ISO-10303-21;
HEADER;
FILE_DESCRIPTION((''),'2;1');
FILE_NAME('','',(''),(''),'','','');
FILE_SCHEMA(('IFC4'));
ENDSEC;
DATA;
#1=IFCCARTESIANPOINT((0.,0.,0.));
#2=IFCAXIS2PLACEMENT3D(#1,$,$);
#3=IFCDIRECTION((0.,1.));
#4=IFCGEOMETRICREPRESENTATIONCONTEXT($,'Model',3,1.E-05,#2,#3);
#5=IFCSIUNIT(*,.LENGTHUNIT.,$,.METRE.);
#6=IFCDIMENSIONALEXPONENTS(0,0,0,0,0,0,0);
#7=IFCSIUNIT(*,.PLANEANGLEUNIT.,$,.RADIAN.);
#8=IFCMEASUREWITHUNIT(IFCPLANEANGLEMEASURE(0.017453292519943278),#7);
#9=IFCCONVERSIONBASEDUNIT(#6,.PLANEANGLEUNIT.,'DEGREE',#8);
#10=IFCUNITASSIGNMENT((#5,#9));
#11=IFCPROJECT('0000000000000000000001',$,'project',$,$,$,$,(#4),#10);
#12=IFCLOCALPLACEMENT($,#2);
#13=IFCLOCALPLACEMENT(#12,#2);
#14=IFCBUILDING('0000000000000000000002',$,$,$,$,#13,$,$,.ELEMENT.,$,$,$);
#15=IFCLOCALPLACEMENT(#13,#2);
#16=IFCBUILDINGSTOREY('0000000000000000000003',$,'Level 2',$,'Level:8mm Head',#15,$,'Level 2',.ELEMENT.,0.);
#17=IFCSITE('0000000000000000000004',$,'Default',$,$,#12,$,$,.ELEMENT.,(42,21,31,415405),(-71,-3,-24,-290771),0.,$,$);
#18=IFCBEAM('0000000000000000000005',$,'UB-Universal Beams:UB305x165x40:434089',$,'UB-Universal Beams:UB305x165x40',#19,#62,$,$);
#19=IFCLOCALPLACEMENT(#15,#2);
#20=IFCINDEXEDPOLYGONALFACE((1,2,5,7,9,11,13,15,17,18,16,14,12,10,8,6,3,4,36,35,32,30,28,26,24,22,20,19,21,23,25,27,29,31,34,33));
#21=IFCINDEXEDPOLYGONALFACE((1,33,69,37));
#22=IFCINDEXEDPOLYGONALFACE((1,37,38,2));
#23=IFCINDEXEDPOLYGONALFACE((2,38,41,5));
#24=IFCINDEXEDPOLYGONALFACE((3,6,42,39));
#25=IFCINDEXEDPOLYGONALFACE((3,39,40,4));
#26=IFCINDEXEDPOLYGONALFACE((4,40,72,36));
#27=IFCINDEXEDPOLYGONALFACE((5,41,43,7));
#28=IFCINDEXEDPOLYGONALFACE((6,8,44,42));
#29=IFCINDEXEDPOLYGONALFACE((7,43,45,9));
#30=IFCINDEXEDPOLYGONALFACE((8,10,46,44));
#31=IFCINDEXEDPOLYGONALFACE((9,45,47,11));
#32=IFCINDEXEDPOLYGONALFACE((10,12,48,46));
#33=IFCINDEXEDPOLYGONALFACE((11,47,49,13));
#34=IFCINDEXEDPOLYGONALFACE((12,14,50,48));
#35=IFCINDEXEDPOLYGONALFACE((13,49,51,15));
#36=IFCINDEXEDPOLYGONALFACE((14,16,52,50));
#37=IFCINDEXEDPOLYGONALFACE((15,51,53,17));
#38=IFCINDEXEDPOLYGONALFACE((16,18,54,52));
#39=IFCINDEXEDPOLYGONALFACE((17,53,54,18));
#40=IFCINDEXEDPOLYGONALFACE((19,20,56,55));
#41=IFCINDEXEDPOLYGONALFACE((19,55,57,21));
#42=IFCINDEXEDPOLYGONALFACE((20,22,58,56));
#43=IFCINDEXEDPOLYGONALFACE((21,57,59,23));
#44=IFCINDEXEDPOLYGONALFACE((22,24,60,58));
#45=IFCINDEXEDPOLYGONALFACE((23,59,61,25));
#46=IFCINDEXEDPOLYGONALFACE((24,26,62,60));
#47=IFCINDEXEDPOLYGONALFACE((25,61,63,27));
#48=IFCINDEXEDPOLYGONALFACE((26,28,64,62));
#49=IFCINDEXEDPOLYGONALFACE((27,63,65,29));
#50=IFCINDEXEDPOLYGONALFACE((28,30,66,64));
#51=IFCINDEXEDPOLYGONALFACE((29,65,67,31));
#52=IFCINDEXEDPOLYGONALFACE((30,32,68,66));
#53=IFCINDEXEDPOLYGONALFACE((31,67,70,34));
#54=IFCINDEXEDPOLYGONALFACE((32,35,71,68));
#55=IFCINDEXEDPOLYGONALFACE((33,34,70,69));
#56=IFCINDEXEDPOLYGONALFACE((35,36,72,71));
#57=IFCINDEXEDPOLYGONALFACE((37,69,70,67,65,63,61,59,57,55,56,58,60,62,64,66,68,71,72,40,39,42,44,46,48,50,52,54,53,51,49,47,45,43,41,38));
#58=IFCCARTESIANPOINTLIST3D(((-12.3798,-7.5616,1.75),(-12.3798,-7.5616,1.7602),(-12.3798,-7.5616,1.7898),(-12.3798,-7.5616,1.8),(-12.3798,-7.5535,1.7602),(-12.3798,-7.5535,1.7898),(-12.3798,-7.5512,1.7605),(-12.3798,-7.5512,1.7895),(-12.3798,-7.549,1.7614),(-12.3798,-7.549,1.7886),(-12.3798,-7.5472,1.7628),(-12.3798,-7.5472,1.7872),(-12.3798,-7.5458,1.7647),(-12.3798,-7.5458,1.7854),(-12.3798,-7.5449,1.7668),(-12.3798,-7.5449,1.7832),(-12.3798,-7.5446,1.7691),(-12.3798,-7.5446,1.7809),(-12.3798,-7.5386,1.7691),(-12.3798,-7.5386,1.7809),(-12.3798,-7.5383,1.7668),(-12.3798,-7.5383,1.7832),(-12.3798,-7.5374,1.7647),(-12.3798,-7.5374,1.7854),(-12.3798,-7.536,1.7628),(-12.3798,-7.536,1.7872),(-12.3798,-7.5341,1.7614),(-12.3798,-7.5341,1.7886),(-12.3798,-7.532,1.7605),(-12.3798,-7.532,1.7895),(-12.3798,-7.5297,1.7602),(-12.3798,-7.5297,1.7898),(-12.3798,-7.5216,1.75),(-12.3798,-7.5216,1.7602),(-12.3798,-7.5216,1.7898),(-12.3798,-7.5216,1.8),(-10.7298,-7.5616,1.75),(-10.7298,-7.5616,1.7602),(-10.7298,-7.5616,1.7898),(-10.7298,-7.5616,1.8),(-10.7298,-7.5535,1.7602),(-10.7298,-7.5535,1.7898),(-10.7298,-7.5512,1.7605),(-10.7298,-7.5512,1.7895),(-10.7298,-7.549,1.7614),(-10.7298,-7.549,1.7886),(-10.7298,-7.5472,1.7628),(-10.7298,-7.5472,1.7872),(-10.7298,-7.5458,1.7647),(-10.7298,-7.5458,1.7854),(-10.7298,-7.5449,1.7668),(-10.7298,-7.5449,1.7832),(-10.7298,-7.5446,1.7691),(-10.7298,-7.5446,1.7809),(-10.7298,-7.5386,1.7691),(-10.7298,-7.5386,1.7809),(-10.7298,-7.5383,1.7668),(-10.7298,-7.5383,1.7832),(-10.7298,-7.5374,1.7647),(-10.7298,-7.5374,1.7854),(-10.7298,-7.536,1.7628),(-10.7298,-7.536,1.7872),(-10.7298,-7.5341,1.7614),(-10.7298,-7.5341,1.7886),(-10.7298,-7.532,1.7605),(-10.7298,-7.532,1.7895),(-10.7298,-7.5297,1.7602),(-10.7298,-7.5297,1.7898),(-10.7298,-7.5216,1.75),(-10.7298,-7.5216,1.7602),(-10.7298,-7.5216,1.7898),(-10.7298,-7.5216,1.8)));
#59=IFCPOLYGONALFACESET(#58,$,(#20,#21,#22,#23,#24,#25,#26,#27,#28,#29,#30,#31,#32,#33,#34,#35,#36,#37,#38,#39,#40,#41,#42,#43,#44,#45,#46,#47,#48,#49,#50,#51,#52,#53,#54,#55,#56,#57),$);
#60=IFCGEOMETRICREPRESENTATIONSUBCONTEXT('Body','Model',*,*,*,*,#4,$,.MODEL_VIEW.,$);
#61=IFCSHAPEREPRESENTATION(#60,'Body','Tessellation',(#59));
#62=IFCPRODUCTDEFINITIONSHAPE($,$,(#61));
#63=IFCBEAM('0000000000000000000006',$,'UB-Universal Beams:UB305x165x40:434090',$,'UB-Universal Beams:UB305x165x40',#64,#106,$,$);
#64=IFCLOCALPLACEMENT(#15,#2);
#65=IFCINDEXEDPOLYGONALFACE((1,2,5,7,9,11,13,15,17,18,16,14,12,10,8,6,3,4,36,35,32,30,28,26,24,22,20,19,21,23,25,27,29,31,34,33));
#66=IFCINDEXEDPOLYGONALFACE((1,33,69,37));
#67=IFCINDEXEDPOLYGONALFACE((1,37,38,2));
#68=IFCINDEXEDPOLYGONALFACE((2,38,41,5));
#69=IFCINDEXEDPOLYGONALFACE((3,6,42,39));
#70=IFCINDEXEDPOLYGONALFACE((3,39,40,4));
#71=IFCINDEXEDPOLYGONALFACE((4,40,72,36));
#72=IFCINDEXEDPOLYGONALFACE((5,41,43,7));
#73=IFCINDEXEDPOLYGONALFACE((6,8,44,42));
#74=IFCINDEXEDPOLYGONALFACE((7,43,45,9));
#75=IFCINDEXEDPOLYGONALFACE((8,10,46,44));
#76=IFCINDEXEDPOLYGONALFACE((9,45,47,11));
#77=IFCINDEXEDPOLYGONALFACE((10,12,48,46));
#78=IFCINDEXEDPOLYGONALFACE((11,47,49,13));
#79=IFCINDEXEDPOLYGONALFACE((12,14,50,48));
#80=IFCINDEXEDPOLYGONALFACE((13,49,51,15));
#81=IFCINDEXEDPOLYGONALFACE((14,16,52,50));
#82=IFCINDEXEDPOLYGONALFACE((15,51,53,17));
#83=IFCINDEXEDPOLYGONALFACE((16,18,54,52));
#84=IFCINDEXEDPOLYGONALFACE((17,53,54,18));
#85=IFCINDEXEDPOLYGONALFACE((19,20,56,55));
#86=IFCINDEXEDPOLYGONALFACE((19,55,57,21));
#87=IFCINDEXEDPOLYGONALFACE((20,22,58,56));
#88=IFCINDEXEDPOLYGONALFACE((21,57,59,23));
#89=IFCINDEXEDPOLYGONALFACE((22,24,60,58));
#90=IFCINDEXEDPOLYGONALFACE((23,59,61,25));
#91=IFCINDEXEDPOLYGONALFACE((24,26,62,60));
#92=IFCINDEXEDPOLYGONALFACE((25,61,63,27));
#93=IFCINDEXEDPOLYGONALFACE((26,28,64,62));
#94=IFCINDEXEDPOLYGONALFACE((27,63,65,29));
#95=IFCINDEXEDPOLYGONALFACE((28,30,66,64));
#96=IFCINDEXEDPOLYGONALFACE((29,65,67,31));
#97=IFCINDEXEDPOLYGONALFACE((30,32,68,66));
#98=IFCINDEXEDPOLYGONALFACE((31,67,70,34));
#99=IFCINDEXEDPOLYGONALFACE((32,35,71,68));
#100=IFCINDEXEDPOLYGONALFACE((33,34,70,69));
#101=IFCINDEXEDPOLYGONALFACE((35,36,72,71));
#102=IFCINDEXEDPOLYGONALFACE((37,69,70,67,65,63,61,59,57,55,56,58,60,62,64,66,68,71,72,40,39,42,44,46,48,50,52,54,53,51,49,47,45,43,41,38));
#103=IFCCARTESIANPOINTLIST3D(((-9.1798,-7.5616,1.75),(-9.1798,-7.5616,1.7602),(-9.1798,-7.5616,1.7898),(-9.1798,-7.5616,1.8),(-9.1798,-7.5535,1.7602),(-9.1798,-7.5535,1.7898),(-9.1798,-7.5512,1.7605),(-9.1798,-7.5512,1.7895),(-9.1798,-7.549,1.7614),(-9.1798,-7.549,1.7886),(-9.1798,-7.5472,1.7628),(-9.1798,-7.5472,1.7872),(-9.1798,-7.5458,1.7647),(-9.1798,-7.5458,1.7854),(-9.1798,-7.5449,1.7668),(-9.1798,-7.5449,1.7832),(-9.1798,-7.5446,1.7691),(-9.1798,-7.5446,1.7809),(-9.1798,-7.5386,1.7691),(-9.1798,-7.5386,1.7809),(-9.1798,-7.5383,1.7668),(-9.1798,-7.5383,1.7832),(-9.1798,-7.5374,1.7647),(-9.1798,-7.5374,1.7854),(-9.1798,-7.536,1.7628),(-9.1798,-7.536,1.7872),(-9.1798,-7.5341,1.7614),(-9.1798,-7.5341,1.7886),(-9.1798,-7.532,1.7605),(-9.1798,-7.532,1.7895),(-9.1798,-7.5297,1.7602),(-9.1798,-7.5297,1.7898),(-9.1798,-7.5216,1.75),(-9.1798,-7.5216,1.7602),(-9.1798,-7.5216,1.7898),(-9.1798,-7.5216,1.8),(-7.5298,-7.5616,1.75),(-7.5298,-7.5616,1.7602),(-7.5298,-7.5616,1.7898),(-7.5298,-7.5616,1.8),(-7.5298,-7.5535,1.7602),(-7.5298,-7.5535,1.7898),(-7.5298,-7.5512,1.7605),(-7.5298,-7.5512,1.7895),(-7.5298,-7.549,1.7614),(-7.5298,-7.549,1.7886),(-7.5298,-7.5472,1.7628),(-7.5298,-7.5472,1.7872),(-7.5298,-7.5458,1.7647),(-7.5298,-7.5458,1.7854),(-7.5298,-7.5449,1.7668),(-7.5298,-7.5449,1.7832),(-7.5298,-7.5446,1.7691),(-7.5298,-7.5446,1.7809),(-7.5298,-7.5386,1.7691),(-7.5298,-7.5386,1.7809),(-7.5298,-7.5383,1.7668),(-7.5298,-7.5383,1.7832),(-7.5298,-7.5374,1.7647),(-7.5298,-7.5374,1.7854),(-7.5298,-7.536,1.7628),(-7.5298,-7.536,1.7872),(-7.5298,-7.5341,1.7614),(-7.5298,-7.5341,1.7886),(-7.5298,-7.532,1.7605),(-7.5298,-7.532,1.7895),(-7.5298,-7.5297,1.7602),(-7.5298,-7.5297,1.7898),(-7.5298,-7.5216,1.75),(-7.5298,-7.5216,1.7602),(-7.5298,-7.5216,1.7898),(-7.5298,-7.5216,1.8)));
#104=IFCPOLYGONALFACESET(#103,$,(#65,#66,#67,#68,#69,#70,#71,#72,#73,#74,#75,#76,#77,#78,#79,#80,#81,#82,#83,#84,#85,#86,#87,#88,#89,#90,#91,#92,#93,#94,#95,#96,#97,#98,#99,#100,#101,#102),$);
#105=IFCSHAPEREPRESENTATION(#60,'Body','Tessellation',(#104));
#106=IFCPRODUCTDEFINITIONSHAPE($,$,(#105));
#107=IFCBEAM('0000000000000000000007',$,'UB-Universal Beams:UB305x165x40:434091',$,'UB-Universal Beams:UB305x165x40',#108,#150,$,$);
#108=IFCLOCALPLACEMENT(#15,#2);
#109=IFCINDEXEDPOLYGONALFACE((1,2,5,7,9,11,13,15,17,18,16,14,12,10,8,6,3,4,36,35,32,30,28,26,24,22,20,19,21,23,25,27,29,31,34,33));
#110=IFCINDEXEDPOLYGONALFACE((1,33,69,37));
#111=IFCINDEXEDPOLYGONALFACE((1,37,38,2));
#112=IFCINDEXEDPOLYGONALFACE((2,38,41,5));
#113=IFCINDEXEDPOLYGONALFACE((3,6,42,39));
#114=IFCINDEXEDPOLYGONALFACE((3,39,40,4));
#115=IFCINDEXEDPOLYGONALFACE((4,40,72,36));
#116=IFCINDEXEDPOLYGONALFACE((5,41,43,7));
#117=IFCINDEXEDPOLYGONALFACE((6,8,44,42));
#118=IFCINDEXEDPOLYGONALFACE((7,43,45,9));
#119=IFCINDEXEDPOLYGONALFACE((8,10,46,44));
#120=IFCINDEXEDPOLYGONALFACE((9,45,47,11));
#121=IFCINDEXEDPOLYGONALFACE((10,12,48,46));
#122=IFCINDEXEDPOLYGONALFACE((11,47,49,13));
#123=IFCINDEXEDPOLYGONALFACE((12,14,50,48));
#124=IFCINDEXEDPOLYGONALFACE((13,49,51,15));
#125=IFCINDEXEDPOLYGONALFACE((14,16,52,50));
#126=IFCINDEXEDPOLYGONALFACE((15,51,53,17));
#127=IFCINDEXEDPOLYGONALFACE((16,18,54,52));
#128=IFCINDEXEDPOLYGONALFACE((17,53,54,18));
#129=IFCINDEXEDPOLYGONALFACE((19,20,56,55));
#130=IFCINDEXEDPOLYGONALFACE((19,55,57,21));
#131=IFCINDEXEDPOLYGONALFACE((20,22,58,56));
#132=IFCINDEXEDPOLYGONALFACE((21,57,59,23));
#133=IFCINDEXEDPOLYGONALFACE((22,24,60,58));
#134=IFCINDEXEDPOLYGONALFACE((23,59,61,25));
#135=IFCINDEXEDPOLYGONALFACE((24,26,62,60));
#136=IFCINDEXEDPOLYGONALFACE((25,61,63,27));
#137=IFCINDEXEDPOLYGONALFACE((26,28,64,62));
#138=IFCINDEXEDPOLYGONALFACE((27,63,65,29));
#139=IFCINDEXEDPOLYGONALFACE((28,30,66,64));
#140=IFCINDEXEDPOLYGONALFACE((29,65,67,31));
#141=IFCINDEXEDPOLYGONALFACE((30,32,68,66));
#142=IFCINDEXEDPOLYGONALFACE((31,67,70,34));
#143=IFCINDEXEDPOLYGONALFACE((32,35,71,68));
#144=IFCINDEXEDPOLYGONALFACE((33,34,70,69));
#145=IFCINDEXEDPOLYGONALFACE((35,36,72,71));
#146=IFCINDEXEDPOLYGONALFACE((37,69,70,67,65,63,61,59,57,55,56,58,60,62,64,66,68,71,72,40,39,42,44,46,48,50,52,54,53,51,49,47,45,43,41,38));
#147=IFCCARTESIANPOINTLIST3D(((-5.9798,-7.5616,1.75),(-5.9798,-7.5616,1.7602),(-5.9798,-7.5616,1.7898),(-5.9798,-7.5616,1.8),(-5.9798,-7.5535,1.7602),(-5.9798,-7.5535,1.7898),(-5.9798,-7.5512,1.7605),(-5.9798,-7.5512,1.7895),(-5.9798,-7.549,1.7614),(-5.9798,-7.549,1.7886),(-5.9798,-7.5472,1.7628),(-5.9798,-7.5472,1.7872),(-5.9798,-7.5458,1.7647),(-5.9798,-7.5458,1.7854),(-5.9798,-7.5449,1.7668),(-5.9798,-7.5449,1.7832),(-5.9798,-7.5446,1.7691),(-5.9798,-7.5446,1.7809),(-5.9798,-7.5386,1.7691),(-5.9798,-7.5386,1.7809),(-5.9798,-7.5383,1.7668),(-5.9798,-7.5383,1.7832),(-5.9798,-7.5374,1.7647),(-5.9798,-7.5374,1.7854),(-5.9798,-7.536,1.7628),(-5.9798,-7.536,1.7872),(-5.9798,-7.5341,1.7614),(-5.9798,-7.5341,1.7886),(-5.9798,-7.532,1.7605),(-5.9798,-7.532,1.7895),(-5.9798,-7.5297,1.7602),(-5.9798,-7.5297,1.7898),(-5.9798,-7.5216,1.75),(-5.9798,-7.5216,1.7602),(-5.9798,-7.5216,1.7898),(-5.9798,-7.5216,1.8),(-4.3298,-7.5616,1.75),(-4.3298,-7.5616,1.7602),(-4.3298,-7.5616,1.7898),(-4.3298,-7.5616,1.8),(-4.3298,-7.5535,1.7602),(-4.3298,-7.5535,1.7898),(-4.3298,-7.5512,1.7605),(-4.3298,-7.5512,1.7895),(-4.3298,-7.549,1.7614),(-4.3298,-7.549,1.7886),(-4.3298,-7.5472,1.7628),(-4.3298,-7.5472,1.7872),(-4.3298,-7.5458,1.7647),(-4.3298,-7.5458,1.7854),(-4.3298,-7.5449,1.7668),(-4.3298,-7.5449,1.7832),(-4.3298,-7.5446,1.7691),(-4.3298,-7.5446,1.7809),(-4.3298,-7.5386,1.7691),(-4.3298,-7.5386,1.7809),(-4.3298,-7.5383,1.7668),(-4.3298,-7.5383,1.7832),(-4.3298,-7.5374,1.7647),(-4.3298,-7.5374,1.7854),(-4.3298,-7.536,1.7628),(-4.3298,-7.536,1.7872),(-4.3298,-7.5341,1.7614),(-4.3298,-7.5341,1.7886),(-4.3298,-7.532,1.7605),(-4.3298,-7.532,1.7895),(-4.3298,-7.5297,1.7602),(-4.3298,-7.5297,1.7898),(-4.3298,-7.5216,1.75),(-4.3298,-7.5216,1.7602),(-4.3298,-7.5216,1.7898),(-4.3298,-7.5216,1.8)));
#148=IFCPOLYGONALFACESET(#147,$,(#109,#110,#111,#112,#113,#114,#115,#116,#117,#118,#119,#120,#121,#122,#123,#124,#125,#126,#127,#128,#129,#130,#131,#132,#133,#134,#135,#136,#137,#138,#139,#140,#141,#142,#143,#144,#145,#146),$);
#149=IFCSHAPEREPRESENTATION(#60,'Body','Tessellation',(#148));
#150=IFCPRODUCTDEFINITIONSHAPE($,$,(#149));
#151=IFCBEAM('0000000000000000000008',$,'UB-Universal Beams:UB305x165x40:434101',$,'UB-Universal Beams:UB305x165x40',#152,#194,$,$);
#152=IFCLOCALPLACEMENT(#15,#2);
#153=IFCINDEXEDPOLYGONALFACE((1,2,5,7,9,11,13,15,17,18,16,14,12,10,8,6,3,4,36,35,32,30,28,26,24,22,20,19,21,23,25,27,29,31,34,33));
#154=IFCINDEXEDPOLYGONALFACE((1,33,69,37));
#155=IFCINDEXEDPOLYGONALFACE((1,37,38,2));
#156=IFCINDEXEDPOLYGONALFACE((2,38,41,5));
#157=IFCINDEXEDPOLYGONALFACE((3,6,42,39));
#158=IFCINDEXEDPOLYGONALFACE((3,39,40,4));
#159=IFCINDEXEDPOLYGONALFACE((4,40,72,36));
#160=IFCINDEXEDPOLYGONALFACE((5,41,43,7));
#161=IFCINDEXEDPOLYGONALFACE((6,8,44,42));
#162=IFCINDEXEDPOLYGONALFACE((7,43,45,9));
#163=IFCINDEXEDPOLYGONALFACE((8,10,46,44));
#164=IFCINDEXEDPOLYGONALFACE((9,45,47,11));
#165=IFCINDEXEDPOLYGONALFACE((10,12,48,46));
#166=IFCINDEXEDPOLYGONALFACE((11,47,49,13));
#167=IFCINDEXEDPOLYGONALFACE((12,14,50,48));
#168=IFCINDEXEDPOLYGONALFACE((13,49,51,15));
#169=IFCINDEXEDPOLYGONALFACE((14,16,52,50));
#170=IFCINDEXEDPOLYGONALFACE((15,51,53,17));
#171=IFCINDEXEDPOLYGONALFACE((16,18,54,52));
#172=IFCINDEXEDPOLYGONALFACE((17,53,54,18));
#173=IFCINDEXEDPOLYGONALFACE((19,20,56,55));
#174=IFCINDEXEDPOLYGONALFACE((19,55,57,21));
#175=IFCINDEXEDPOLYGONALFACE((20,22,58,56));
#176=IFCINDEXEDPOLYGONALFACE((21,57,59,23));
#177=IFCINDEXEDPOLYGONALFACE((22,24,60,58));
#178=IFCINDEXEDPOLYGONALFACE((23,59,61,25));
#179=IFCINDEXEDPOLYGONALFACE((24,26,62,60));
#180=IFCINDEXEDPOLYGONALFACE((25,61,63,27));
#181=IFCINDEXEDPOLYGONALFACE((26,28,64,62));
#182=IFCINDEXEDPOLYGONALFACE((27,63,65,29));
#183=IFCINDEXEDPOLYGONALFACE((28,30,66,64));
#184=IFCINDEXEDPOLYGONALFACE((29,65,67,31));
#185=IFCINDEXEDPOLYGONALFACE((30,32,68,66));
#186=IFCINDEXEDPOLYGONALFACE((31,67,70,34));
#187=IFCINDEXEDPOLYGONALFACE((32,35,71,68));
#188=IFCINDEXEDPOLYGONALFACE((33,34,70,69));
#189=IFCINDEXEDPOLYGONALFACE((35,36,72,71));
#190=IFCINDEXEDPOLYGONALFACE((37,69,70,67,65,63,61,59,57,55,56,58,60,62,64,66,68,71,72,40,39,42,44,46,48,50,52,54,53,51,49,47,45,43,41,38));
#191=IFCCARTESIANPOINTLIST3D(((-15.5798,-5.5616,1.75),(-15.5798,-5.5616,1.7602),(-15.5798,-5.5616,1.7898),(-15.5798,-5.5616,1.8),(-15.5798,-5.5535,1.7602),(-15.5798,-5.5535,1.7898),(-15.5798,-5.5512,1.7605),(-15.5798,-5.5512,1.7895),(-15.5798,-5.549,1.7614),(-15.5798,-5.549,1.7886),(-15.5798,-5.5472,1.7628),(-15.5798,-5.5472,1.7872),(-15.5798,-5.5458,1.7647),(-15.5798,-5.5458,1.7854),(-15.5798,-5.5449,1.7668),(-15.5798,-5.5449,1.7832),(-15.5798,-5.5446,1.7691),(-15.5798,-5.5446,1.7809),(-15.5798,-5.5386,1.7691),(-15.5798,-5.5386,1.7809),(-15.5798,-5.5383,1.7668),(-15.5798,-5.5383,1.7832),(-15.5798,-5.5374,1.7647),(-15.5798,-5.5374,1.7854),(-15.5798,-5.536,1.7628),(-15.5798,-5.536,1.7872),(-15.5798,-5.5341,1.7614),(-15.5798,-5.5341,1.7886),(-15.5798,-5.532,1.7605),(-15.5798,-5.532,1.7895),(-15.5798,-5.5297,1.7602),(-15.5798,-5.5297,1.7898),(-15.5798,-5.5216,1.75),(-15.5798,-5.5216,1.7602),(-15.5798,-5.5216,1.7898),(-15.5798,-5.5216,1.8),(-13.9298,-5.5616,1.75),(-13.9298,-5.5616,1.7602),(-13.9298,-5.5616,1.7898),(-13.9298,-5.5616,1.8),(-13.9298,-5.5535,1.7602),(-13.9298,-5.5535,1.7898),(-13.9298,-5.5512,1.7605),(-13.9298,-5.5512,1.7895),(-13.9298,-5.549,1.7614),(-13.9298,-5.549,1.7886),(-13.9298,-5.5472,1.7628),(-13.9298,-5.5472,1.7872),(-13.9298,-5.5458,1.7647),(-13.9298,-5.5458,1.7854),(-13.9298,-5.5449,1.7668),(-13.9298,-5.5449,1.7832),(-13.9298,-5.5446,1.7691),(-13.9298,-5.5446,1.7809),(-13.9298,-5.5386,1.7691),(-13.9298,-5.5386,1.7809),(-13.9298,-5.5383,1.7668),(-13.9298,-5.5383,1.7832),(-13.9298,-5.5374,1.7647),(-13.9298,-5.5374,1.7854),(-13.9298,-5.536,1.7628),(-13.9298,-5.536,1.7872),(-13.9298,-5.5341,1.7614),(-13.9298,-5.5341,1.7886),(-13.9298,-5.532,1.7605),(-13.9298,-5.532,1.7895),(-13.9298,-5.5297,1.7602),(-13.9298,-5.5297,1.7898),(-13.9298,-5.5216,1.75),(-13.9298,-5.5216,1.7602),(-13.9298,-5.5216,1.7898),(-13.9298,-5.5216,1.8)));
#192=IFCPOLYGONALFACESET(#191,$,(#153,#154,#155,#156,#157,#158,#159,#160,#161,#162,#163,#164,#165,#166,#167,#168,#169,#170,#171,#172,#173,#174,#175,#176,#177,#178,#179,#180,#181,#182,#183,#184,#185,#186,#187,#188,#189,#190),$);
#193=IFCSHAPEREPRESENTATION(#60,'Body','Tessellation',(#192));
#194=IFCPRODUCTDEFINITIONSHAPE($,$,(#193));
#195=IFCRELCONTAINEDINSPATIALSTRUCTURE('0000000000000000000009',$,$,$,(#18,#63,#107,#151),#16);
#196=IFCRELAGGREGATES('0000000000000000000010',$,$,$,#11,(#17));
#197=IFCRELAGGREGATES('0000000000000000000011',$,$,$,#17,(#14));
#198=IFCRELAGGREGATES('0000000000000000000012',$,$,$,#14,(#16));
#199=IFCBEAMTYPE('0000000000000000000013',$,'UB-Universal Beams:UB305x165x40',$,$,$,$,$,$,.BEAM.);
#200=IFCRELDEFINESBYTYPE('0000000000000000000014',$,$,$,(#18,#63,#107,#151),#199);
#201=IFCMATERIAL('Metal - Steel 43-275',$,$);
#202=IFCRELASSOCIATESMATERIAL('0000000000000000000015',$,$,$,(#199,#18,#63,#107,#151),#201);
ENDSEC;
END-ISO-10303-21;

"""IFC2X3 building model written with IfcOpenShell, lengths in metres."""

from ifc_helpers import new_model, entity, si_unit, converted_unit, direction, frame, frame_2d, origin, place, context, subcontext, project, spatial, i_section, extrude, material, type_object, element, save


model = new_model("IFC2X3")

# Units and contexts
model_context = context("Model", 3, precision=1e-05, world=origin(), true_north=direction((0.0, 1.0)))
body_context = subcontext(model_context, "Body", "Model", "MODEL_VIEW")
ifc_project = project(units=[si_unit("LENGTHUNIT", "METRE"), converted_unit("PLANEANGLEUNIT", "DEGREE", entity("IfcPlaneAngleMeasure", 0.017453292519943278), si_unit("PLANEANGLEUNIT", "RADIAN"), dimensions=[0, 0, 0, 0, 0, 0, 0])], contexts=[model_context])

# Site, building, storey
site_placement = place(None, origin())
site = spatial("IfcSite", under=ifc_project, at=site_placement, Name="Default", CompositionType="ELEMENT", RefLatitude=(42, 21, 31, 415405), RefLongitude=(-71, -3, -24, -290771), RefElevation=0.0)
building_placement = place(site_placement, origin())
building = spatial("IfcBuilding", under=site, at=building_placement, CompositionType="ELEMENT")
storey_placement = place(building_placement, origin())
storey = spatial("IfcBuildingStorey", under=building, at=storey_placement, Name="Level 2", ObjectType="Level:8mm Head", LongName="Level 2", CompositionType="ELEMENT", Elevation=0.0)

# Shared definitions
ifc_material = material(Name="Metal - Steel 43-275")

# Beams
beam_type = type_object("IfcBeamType", Name="UB-Universal Beams:UB305x165x40", PredefinedType="BEAM", material=ifc_material)
for number, where, name in (
    (1, (-12.3798, -7.5416, 1.8), "UB-Universal Beams:UB305x165x40:434089"),
):
    element("IfcBeam", number, at=place(storey_placement, frame(where)), inside=storey, type_object=beam_type, material=ifc_material, Name=name, ObjectType="UB-Universal Beams:UB305x165x40", context=body_context, shape_type="SweptSolid", body=[
        extrude(i_section(OverallWidth=0.04, OverallDepth=0.05, WebThickness=0.006, FlangeThickness=0.0102, FilletRadius=0.0089, at=frame_2d((0.0, 0.0), x_axis=(0.0, 1.0))), frame((0.0, 0.0, -0.025), z_axis=(1.0, 0.0, 0.0), x_axis=(0.0, 0.0, -1.0)), (0.0, 0.0, 1.0), 1.65),
    ])
for number, where, name in (
    (2, (-9.1798, -7.5416, 1.8), "UB-Universal Beams:UB305x165x40:434090"),
    (3, (-5.9798, -7.5416, 1.8), "UB-Universal Beams:UB305x165x40:434091"),
):
    element("IfcBeam", number, at=place(storey_placement, frame(where)), inside=storey, type_object=beam_type, material=ifc_material, Name=name, ObjectType="UB-Universal Beams:UB305x165x40", context=body_context, shape_type="SweptSolid", body=[
        extrude(i_section(OverallWidth=0.04, OverallDepth=0.05, WebThickness=0.006, FlangeThickness=0.0102, FilletRadius=0.0089, at=frame_2d((0.0, 0.0), x_axis=(0.0, 1.0))), frame((0.0, 0.0, -0.025), z_axis=(1.0, 0.0, 0.0), x_axis=(0.0, 0.0, -1.0)), (0.0, 0.0, 1.0), 1.65),
    ])
for number, where, name in (
    (4, (-15.5798, -5.5416, 1.8), "UB-Universal Beams:UB305x165x40:434101"),
):
    element("IfcBeam", number, at=place(storey_placement, frame(where)), inside=storey, type_object=beam_type, material=ifc_material, Name=name, ObjectType="UB-Universal Beams:UB305x165x40", context=body_context, shape_type="SweptSolid", body=[
        extrude(i_section(OverallWidth=0.04, OverallDepth=0.05, WebThickness=0.006, FlangeThickness=0.0102, FilletRadius=0.0089, at=frame_2d((0.0, 0.0), x_axis=(0.0, 1.0))), frame((0.0, 0.0, -0.025), z_axis=(1.0, 0.0, 0.0), x_axis=(0.0, 0.0, -1.0)), (0.0, 0.0, 1.0), 1.65),
    ])

save(model, "model.ifc")
